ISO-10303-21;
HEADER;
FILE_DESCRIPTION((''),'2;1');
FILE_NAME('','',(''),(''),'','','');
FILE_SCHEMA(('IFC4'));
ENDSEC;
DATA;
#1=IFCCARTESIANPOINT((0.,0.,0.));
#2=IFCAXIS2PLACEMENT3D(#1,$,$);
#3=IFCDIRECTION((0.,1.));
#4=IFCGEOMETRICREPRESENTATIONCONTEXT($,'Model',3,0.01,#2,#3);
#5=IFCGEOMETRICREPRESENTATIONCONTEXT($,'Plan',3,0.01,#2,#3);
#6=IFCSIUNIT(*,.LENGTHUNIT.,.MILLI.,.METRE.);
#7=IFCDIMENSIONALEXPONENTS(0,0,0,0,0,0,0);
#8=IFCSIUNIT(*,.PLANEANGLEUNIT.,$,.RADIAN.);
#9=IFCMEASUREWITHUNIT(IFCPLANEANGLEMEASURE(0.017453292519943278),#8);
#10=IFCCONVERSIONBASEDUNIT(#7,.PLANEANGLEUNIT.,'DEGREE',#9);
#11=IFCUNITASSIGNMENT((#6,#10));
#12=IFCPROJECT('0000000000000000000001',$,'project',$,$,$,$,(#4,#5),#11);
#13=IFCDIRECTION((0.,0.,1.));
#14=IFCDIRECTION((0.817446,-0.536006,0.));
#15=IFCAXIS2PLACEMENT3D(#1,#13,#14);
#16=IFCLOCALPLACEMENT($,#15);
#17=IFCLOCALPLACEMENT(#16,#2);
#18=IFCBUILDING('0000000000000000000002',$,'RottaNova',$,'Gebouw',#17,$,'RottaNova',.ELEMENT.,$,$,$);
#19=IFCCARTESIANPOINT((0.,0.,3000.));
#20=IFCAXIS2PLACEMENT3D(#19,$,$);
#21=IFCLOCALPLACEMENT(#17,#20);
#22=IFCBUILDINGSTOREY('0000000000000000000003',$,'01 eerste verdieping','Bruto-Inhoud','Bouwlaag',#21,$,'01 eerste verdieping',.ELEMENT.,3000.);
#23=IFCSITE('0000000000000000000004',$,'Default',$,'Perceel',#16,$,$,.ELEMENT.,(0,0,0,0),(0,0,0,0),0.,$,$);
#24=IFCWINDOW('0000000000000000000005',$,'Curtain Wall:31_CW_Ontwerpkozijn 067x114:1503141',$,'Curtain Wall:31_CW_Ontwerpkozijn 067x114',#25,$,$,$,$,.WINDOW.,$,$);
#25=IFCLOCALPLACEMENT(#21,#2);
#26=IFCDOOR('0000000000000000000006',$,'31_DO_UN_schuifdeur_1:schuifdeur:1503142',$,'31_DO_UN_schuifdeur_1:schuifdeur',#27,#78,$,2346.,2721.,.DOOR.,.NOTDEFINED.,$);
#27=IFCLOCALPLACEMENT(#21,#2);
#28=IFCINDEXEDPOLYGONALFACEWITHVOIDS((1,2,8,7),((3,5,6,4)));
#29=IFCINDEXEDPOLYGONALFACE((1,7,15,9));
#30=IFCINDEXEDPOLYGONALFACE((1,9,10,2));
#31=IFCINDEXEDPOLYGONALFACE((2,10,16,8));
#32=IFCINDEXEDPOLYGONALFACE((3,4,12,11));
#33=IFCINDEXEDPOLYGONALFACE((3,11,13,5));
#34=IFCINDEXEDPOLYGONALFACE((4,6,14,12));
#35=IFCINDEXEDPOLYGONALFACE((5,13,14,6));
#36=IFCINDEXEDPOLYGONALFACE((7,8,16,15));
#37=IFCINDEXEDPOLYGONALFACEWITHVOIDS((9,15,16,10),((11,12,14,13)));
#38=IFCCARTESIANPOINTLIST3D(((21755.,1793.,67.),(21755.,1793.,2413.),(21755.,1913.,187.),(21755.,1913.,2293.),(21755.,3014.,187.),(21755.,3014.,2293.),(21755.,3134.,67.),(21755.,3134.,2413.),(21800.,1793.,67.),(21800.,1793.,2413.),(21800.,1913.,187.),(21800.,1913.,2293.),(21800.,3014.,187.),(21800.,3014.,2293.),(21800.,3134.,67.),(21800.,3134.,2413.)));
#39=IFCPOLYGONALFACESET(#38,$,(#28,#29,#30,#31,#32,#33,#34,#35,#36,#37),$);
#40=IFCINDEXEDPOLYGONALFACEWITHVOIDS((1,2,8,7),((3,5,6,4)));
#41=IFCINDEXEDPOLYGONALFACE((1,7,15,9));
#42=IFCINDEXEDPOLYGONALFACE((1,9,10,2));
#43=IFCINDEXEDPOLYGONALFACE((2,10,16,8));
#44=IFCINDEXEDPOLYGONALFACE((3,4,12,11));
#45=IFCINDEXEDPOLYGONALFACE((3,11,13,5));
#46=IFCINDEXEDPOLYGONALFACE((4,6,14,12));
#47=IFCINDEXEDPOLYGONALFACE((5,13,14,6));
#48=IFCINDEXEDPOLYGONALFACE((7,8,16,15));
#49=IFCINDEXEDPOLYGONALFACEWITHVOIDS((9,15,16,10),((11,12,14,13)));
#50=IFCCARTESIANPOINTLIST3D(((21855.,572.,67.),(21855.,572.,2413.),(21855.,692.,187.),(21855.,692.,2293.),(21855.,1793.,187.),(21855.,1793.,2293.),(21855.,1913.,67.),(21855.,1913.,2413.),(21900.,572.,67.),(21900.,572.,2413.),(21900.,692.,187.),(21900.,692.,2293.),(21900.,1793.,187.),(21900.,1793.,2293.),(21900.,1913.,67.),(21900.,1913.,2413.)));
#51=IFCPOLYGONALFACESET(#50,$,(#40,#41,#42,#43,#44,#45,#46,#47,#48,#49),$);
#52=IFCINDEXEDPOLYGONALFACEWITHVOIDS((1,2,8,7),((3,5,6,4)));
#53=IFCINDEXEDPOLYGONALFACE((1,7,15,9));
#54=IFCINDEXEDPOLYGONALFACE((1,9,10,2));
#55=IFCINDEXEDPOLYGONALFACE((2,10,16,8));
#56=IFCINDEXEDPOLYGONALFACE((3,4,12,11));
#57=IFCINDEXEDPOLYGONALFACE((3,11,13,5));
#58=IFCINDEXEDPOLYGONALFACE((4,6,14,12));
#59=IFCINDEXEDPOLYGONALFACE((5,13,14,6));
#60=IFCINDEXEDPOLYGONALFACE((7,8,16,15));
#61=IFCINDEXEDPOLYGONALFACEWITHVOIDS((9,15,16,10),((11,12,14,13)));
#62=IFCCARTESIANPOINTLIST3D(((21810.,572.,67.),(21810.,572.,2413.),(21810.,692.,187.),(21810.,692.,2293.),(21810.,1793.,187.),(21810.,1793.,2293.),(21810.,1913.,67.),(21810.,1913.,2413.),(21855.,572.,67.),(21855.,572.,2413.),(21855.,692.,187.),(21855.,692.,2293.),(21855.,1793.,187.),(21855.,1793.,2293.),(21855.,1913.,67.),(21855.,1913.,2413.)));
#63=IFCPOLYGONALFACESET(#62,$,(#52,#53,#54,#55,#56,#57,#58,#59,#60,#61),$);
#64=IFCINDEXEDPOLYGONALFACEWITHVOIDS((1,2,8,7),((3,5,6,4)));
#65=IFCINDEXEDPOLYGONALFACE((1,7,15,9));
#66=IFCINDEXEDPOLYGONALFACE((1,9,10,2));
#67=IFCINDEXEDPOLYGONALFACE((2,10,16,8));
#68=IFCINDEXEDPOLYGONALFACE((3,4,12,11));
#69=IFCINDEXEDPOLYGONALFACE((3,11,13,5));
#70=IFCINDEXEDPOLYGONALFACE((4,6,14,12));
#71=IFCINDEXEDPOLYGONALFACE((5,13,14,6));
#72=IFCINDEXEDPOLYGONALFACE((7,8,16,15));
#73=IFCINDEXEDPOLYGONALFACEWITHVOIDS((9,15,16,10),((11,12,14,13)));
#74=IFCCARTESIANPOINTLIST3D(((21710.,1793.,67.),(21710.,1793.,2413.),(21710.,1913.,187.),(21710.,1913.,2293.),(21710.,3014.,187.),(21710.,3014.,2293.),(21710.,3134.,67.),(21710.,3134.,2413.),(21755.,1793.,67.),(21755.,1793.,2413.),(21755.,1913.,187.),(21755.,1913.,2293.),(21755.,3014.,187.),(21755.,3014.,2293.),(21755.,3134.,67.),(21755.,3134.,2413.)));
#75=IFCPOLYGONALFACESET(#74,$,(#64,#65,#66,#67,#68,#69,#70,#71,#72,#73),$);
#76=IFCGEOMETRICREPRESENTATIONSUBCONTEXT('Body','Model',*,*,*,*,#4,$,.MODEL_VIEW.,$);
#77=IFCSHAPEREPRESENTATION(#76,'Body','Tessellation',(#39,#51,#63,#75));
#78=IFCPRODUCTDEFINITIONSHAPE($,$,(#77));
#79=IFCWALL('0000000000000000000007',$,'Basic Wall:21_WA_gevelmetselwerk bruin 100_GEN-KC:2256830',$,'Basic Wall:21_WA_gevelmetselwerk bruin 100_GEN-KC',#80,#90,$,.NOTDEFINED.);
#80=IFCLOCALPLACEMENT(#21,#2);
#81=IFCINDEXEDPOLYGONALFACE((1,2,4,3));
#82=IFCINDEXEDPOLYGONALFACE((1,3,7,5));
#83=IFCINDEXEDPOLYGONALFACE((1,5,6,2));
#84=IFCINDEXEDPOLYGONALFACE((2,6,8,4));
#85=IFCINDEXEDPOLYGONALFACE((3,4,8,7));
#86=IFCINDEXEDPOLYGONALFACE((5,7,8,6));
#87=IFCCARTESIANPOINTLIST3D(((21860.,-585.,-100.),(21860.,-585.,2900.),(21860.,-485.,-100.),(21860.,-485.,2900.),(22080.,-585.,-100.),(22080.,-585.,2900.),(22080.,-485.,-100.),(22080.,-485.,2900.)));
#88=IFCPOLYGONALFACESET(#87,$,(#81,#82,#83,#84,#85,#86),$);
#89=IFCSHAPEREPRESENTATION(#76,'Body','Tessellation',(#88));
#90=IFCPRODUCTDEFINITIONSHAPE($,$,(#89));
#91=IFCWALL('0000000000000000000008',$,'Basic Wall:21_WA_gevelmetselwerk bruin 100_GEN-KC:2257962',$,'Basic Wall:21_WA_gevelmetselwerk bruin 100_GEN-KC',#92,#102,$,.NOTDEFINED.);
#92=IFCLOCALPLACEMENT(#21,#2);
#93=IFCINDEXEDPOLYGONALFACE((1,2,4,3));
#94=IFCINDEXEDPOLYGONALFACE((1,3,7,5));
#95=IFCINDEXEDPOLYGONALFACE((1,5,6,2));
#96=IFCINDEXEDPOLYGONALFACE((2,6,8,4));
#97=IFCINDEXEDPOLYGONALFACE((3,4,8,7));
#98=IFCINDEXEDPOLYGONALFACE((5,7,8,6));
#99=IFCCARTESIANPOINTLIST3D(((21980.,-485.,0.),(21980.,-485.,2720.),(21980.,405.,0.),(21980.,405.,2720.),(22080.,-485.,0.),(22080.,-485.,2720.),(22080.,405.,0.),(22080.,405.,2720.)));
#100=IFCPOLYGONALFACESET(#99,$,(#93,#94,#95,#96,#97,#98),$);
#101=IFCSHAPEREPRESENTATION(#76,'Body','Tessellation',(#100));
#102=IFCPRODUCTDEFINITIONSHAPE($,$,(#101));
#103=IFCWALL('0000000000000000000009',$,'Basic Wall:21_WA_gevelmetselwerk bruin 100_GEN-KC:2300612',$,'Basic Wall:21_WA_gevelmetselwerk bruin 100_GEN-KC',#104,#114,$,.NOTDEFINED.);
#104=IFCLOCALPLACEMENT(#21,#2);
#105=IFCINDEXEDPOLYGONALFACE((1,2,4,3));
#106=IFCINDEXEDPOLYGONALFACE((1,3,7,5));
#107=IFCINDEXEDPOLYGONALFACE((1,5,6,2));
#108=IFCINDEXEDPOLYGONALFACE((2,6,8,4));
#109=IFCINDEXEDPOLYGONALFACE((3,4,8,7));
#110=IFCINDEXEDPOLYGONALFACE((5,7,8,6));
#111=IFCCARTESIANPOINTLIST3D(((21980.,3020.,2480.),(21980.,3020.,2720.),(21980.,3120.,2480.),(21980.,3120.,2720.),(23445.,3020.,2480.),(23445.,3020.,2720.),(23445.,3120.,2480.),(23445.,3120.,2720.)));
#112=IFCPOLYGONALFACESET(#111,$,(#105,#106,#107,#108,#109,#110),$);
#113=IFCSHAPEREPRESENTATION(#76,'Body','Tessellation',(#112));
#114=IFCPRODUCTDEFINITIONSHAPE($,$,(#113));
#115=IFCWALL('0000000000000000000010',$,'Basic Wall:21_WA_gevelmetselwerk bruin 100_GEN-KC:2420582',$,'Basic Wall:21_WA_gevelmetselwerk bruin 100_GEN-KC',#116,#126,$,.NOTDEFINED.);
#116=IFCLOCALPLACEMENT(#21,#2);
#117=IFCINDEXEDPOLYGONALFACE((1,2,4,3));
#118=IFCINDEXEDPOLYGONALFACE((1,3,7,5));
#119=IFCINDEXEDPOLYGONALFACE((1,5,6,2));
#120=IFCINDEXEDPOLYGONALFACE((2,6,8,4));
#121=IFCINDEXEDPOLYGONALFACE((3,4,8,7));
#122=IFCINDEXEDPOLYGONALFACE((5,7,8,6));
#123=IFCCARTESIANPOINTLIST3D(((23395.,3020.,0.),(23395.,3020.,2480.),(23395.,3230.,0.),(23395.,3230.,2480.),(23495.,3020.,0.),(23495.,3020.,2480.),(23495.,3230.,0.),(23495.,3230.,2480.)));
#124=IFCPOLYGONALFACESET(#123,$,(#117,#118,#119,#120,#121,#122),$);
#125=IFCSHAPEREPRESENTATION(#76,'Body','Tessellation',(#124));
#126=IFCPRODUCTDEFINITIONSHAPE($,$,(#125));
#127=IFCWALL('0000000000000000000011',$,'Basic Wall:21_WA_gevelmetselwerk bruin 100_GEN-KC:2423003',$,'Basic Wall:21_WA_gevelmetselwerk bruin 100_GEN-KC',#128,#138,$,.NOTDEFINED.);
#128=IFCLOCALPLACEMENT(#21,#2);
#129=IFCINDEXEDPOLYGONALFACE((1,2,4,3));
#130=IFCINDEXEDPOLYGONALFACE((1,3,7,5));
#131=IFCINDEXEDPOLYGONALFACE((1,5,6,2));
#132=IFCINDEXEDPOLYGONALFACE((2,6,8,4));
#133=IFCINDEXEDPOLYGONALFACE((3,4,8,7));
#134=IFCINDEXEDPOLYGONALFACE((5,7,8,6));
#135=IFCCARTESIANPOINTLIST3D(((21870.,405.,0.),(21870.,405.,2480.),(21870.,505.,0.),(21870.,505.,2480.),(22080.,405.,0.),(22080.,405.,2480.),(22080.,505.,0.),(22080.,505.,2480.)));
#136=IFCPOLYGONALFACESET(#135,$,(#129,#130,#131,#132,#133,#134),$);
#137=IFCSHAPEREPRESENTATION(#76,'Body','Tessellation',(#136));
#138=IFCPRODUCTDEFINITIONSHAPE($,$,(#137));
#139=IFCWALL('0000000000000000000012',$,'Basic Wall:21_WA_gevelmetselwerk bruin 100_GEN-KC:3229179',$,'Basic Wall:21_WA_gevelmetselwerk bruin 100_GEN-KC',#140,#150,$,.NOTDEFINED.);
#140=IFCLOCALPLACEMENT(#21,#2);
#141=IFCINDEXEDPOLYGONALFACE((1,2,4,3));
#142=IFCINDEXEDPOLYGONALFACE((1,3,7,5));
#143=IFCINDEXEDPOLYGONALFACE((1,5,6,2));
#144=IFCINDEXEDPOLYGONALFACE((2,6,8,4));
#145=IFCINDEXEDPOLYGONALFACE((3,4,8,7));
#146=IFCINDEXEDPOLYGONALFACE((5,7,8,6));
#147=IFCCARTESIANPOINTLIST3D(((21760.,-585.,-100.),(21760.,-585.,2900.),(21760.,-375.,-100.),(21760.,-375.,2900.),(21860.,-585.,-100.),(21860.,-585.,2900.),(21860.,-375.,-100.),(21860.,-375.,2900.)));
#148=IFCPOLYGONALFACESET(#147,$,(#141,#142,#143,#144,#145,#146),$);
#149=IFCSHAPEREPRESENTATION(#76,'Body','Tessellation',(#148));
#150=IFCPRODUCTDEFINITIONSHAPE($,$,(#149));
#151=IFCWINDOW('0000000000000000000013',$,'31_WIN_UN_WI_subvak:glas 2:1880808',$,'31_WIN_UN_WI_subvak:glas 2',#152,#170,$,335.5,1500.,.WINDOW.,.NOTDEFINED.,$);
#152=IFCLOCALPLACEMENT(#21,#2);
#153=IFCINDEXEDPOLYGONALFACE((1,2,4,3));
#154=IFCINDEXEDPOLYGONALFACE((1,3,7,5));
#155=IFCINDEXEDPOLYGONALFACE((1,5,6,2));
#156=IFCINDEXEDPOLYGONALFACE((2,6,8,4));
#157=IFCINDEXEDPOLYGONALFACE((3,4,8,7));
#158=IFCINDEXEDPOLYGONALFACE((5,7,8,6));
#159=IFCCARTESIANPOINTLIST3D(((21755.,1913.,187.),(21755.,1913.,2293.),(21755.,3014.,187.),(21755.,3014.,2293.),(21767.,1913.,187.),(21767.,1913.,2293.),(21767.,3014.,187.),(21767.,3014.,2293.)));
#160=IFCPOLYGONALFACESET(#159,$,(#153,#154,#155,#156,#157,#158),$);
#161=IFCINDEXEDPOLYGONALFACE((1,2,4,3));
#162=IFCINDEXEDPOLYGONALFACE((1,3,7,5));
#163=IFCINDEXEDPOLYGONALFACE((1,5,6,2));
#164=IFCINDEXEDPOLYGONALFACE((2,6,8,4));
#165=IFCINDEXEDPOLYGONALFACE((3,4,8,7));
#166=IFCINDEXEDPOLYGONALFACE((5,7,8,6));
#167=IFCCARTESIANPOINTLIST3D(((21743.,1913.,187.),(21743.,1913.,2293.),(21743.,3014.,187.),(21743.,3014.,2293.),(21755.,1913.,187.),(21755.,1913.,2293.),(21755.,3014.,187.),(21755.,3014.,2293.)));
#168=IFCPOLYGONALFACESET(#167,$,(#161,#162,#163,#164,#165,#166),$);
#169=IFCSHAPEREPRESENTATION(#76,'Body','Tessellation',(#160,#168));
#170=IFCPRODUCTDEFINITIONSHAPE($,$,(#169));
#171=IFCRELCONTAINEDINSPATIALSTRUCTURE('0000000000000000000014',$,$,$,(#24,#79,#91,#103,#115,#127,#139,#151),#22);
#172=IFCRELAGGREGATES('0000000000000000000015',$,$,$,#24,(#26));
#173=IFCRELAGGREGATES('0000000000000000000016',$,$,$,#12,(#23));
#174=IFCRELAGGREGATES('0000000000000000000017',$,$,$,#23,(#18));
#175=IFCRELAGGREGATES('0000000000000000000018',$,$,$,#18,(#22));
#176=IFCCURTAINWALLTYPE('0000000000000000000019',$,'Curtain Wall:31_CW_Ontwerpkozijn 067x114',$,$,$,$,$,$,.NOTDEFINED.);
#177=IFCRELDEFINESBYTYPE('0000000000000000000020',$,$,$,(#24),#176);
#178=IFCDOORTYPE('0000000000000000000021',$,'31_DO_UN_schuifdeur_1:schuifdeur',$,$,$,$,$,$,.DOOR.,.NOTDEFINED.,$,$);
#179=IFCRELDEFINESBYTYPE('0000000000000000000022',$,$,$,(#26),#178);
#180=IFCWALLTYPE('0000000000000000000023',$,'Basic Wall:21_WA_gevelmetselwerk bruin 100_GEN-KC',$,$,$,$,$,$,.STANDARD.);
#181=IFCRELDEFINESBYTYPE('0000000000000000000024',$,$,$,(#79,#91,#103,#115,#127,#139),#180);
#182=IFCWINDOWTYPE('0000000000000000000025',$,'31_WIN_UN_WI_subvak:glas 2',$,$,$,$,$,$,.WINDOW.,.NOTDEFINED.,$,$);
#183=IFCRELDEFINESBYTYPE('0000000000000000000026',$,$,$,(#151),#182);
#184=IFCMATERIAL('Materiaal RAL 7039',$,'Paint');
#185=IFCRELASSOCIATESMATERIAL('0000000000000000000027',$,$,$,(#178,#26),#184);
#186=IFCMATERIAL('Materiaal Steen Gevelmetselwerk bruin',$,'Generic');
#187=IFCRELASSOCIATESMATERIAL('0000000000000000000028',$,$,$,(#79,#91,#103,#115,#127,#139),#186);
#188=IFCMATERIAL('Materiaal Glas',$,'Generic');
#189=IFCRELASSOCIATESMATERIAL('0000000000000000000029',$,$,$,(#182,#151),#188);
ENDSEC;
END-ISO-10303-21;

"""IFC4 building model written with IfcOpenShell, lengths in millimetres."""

from ifc_helpers import new_model, entity, si_unit, converted_unit, direction, frame, origin, place, context, subcontext, project, spatial, indexed_curve, outline, extrude, source, transform, mapped, material, type_object, type_shapes, element, aggregate, save


model = new_model("IFC4")

# Units and contexts
model_context = context("Model", 3, precision=0.01, world=origin(), true_north=direction((0.0, 1.0)))
plan_context = context("Plan", 3, precision=0.01, world=origin(), true_north=direction((0.0, 1.0)))
body_context = subcontext(model_context, "Body", "Model", "MODEL_VIEW")
ifc_project = project(units=[si_unit("LENGTHUNIT", "METRE", prefix="MILLI"), converted_unit("PLANEANGLEUNIT", "DEGREE", entity("IfcPlaneAngleMeasure", 0.017453292519943278), si_unit("PLANEANGLEUNIT", "RADIAN"), dimensions=[0, 0, 0, 0, 0, 0, 0])], contexts=[model_context, plan_context])

# Site, building, storey
site_placement = place(None, frame((0.0, 0.0, 0.0), z_axis=(0.0, 0.0, 1.0), x_axis=(0.817446, -0.536006, 0.0)))
site = spatial("IfcSite", under=ifc_project, at=site_placement, Name="Default", ObjectType="Perceel", CompositionType="ELEMENT", RefLatitude=(0, 0, 0, 0), RefLongitude=(0, 0, 0, 0), RefElevation=0.0)
building_placement = place(site_placement, origin())
building = spatial("IfcBuilding", under=site, at=building_placement, Name="RottaNova", ObjectType="Gebouw", LongName="RottaNova", CompositionType="ELEMENT")
storey_placement = place(building_placement, frame((0.0, 0.0, 3000.0)))
storey = spatial("IfcBuildingStorey", under=building, at=storey_placement, Name="01 eerste verdieping", Description="Bruto-Inhoud", ObjectType="Bouwlaag", LongName="01 eerste verdieping", CompositionType="ELEMENT", Elevation=3000.0)

# Window
curtain_wall_type = type_object("IfcCurtainWallType", Name="Curtain Wall:31_CW_Ontwerpkozijn 067x114", PredefinedType="NOTDEFINED")
window_1_placement = place(storey_placement, frame((0.0, 0.0, -3000.0)))
window_1 = element("IfcWindow", 1, at=window_1_placement, inside=storey, type_object=curtain_wall_type, Name="Curtain Wall:31_CW_Ontwerpkozijn 067x114:1503141", ObjectType="Curtain Wall:31_CW_Ontwerpkozijn 067x114", PredefinedType="WINDOW")
ifc_material_1 = material(Name="Materiaal RAL 7039", Category="Paint")

# Shared definitions
ifc_material_2 = material(Name="Materiaal Glas", Category="Generic")

# Door
door_type = type_object("IfcDoorType", Name="31_DO_UN_schuifdeur_1:schuifdeur", OperationType="NOTDEFINED", PredefinedType="DOOR", material=ifc_material_1)
shared_shape_1 = source(origin(), body_context, "Body", "SweptSolid", [
    extrude(outline(indexed_curve([(-670.5, -1173.0), (670.5, -1173.0), (670.5, 1173.0), (-670.5, 1173.0), (-670.5, -1173.0)], self_intersect=False), holes=[indexed_curve([(-550.5, -1053.0), (-550.5, 1053.0), (550.5, 1053.0), (550.5, -1053.0), (-550.5, -1053.0)], self_intersect=False)]), frame((-610.5, 90.0, 1173.0), z_axis=(0.0, -1.0, 0.0), x_axis=(-1.0, 0.0, 0.0)), (0.0, 0.0, 1.0), 45.0),
    extrude(outline(indexed_curve([(-670.5, -1173.0), (670.5, -1173.0), (670.5, 1173.0), (-670.5, 1173.0), (-670.5, -1173.0)], self_intersect=False), holes=[indexed_curve([(-550.5, -1053.0), (-550.5, 1053.0), (550.5, 1053.0), (550.5, -1053.0), (-550.5, -1053.0)], self_intersect=False)]), frame((610.5, 190.0, 1173.0), z_axis=(0.0, -1.0, 0.0), x_axis=(-1.0, 0.0, 0.0)), (0.0, 0.0, 1.0), 45.0),
    extrude(outline(indexed_curve([(-670.5, -1173.0), (670.5, -1173.0), (670.5, 1173.0), (-670.5, 1173.0), (-670.5, -1173.0)], self_intersect=False), holes=[indexed_curve([(-550.5, -1053.0), (-550.5, 1053.0), (550.5, 1053.0), (550.5, -1053.0), (-550.5, -1053.0)], self_intersect=False)]), frame((610.5, 145.0, 1173.0), z_axis=(0.0, -1.0, 0.0), x_axis=(-1.0, 0.0, 0.0)), (0.0, 0.0, 1.0), 45.0),
    extrude(outline(indexed_curve([(-670.5, -1173.0), (670.5, -1173.0), (670.5, 1173.0), (-670.5, 1173.0), (-670.5, -1173.0)], self_intersect=False), holes=[indexed_curve([(-550.5, -1053.0), (-550.5, 1053.0), (550.5, 1053.0), (550.5, -1053.0), (-550.5, -1053.0)], self_intersect=False)]), frame((-610.5, 45.0, 1173.0), z_axis=(0.0, -1.0, 0.0), x_axis=(-1.0, 0.0, 0.0)), (0.0, 0.0, 1.0), 45.0),
])
type_shapes(door_type, [shared_shape_1])
door_placement = place(window_1_placement, frame((21710.0, 1853.0, 3067.0), z_axis=(0.0, 0.0, 1.0), x_axis=(0.0, -1.0, 0.0)))
door = element("IfcDoor", 2, at=door_placement, type_object=door_type, material=ifc_material_1, Name="31_DO_UN_schuifdeur_1:schuifdeur:1503142", ObjectType="31_DO_UN_schuifdeur_1:schuifdeur", OperationType="NOTDEFINED", OverallHeight=2346.0, OverallWidth=2721.0, PredefinedType="DOOR", context=body_context, shape_type="MappedRepresentation", body=[
    mapped(shared_shape_1, transform((0.0, 0.0, 0.0), scale=1.0)),
])
aggregate(window_1, [door])

# Walls
ifc_material_3 = material(Name="Materiaal Steen Gevelmetselwerk bruin", Category="Generic")
wall_type_1 = type_object("IfcWallType", Name="Basic Wall:21_WA_gevelmetselwerk bruin 100_GEN-KC", PredefinedType="STANDARD")
wall_1_placement = place(storey_placement, frame((21860.0, -535.0, -100.0)))
element("IfcWall", 3, at=wall_1_placement, inside=storey, type_object=wall_type_1, material=ifc_material_3, Name="Basic Wall:21_WA_gevelmetselwerk bruin 100_GEN-KC:2256830", ObjectType="Basic Wall:21_WA_gevelmetselwerk bruin 100_GEN-KC", PredefinedType="NOTDEFINED", context=body_context, shape_type="SweptSolid", body=[
    extrude(outline(indexed_curve([(220.0, 50.0), (0.0, 50.0), (0.0, -50.0), (220.0, -50.0), (220.0, 50.0)], self_intersect=False)), origin(), (0.0, 0.0, 1.0), 3000.0),
])
wall_2_placement = place(storey_placement, frame((22030.0, 405.0, 0.0), z_axis=(0.0, 0.0, 1.0), x_axis=(0.0, -1.0, 0.0)))
element("IfcWall", 4, at=wall_2_placement, inside=storey, type_object=wall_type_1, material=ifc_material_3, Name="Basic Wall:21_WA_gevelmetselwerk bruin 100_GEN-KC:2257962", ObjectType="Basic Wall:21_WA_gevelmetselwerk bruin 100_GEN-KC", PredefinedType="NOTDEFINED", context=body_context, shape_type="SweptSolid", body=[
    extrude(outline(indexed_curve([(890.0, 50.0), (0.0, 50.0), (0.0, -50.0), (890.0, -50.0), (890.0, 50.0)], self_intersect=False)), origin(), (0.0, 0.0, 1.0), 2720.0),
])
wall_3_placement = place(storey_placement, frame((23445.0, 3070.0, 2480.0), z_axis=(0.0, 0.0, 1.0), x_axis=(-1.0, 0.0, 0.0)))
element("IfcWall", 5, at=wall_3_placement, inside=storey, type_object=wall_type_1, material=ifc_material_3, Name="Basic Wall:21_WA_gevelmetselwerk bruin 100_GEN-KC:2300612", ObjectType="Basic Wall:21_WA_gevelmetselwerk bruin 100_GEN-KC", PredefinedType="NOTDEFINED", context=body_context, shape_type="SweptSolid", body=[
    extrude(outline(indexed_curve([(1465.0, 50.0), (0.0, 50.0), (0.0, -50.0), (1465.0, -50.0), (1465.0, 50.0)], self_intersect=False)), origin(), (0.0, 0.0, 1.0), 240.0),
])
wall_4_placement = place(storey_placement, frame((23445.0, 3230.0, 0.0), z_axis=(0.0, 0.0, 1.0), x_axis=(0.0, -1.0, 0.0)))
element("IfcWall", 6, at=wall_4_placement, inside=storey, type_object=wall_type_1, material=ifc_material_3, Name="Basic Wall:21_WA_gevelmetselwerk bruin 100_GEN-KC:2420582", ObjectType="Basic Wall:21_WA_gevelmetselwerk bruin 100_GEN-KC", PredefinedType="NOTDEFINED", context=body_context, shape_type="SweptSolid", body=[
    extrude(outline(indexed_curve([(210.0, 50.0), (0.0, 50.0), (0.0, -50.0), (210.0, -50.0), (210.0, 50.0)], self_intersect=False)), origin(), (0.0, 0.0, 1.0), 2480.0),
])
wall_5_placement = place(storey_placement, frame((21870.0, 455.0, 0.0)))
element("IfcWall", 7, at=wall_5_placement, inside=storey, type_object=wall_type_1, material=ifc_material_3, Name="Basic Wall:21_WA_gevelmetselwerk bruin 100_GEN-KC:2423003", ObjectType="Basic Wall:21_WA_gevelmetselwerk bruin 100_GEN-KC", PredefinedType="NOTDEFINED", context=body_context, shape_type="SweptSolid", body=[
    extrude(outline(indexed_curve([(210.0, 50.0), (0.0, 50.0), (0.0, -50.0), (210.0, -50.0), (210.0, 50.0)], self_intersect=False)), origin(), (0.0, 0.0, 1.0), 2480.0),
])
wall_6_placement = place(storey_placement, frame((21810.0, -585.0, -100.0), z_axis=(0.0, 0.0, 1.0), x_axis=(0.0, 1.0, 0.0)))
element("IfcWall", 8, at=wall_6_placement, inside=storey, type_object=wall_type_1, material=ifc_material_3, Name="Basic Wall:21_WA_gevelmetselwerk bruin 100_GEN-KC:3229179", ObjectType="Basic Wall:21_WA_gevelmetselwerk bruin 100_GEN-KC", PredefinedType="NOTDEFINED", context=body_context, shape_type="SweptSolid", body=[
    extrude(outline(indexed_curve([(210.0, 50.0), (0.0, 50.0), (0.0, -50.0), (210.0, -50.0), (210.0, 50.0)], self_intersect=False)), origin(), (0.0, 0.0, 1.0), 3000.0),
])

# Window
window_type = type_object("IfcWindowType", Name="31_WIN_UN_WI_subvak:glas 2", PartitioningType="NOTDEFINED", PredefinedType="WINDOW", material=ifc_material_2)
shared_shape_2 = source(origin(), body_context, "Body", "SweptSolid", [
    extrude(outline(indexed_curve([(-550.5, -6.0), (550.5, -6.0), (550.5, 6.0), (-550.5, 6.0), (-550.5, -6.0)], self_intersect=False)), frame((0.0, -6.0, 0.0)), (0.0, 0.0, 1.0), 2106.0),
    extrude(outline(indexed_curve([(-550.5, -6.0), (550.5, -6.0), (550.5, 6.0), (-550.5, 6.0), (-550.5, -6.0)], self_intersect=False)), frame((0.0, 6.0, 0.0)), (0.0, 0.0, 1.0), 2106.0),
])
type_shapes(window_type, [shared_shape_2])
for number, where, z_axis, x_axis, name in (
    (9, (21755.0, 2463.5, 187.0), (0.0, 0.0, 1.0), (0.0, 1.0, 0.0), "31_WIN_UN_WI_subvak:glas 2:1880808"),
):
    element("IfcWindow", number, at=place(storey_placement, frame(where, z_axis=z_axis, x_axis=x_axis)), inside=storey, type_object=window_type, material=ifc_material_2, Name=name, ObjectType="31_WIN_UN_WI_subvak:glas 2", OverallHeight=335.5, OverallWidth=1500.0, PartitioningType="NOTDEFINED", PredefinedType="WINDOW", context=body_context, shape_type="MappedRepresentation", body=[
        mapped(shared_shape_2, transform((0.0, 0.0, 0.0), scale=1.0)),
    ])

save(model, "model.ifc")
